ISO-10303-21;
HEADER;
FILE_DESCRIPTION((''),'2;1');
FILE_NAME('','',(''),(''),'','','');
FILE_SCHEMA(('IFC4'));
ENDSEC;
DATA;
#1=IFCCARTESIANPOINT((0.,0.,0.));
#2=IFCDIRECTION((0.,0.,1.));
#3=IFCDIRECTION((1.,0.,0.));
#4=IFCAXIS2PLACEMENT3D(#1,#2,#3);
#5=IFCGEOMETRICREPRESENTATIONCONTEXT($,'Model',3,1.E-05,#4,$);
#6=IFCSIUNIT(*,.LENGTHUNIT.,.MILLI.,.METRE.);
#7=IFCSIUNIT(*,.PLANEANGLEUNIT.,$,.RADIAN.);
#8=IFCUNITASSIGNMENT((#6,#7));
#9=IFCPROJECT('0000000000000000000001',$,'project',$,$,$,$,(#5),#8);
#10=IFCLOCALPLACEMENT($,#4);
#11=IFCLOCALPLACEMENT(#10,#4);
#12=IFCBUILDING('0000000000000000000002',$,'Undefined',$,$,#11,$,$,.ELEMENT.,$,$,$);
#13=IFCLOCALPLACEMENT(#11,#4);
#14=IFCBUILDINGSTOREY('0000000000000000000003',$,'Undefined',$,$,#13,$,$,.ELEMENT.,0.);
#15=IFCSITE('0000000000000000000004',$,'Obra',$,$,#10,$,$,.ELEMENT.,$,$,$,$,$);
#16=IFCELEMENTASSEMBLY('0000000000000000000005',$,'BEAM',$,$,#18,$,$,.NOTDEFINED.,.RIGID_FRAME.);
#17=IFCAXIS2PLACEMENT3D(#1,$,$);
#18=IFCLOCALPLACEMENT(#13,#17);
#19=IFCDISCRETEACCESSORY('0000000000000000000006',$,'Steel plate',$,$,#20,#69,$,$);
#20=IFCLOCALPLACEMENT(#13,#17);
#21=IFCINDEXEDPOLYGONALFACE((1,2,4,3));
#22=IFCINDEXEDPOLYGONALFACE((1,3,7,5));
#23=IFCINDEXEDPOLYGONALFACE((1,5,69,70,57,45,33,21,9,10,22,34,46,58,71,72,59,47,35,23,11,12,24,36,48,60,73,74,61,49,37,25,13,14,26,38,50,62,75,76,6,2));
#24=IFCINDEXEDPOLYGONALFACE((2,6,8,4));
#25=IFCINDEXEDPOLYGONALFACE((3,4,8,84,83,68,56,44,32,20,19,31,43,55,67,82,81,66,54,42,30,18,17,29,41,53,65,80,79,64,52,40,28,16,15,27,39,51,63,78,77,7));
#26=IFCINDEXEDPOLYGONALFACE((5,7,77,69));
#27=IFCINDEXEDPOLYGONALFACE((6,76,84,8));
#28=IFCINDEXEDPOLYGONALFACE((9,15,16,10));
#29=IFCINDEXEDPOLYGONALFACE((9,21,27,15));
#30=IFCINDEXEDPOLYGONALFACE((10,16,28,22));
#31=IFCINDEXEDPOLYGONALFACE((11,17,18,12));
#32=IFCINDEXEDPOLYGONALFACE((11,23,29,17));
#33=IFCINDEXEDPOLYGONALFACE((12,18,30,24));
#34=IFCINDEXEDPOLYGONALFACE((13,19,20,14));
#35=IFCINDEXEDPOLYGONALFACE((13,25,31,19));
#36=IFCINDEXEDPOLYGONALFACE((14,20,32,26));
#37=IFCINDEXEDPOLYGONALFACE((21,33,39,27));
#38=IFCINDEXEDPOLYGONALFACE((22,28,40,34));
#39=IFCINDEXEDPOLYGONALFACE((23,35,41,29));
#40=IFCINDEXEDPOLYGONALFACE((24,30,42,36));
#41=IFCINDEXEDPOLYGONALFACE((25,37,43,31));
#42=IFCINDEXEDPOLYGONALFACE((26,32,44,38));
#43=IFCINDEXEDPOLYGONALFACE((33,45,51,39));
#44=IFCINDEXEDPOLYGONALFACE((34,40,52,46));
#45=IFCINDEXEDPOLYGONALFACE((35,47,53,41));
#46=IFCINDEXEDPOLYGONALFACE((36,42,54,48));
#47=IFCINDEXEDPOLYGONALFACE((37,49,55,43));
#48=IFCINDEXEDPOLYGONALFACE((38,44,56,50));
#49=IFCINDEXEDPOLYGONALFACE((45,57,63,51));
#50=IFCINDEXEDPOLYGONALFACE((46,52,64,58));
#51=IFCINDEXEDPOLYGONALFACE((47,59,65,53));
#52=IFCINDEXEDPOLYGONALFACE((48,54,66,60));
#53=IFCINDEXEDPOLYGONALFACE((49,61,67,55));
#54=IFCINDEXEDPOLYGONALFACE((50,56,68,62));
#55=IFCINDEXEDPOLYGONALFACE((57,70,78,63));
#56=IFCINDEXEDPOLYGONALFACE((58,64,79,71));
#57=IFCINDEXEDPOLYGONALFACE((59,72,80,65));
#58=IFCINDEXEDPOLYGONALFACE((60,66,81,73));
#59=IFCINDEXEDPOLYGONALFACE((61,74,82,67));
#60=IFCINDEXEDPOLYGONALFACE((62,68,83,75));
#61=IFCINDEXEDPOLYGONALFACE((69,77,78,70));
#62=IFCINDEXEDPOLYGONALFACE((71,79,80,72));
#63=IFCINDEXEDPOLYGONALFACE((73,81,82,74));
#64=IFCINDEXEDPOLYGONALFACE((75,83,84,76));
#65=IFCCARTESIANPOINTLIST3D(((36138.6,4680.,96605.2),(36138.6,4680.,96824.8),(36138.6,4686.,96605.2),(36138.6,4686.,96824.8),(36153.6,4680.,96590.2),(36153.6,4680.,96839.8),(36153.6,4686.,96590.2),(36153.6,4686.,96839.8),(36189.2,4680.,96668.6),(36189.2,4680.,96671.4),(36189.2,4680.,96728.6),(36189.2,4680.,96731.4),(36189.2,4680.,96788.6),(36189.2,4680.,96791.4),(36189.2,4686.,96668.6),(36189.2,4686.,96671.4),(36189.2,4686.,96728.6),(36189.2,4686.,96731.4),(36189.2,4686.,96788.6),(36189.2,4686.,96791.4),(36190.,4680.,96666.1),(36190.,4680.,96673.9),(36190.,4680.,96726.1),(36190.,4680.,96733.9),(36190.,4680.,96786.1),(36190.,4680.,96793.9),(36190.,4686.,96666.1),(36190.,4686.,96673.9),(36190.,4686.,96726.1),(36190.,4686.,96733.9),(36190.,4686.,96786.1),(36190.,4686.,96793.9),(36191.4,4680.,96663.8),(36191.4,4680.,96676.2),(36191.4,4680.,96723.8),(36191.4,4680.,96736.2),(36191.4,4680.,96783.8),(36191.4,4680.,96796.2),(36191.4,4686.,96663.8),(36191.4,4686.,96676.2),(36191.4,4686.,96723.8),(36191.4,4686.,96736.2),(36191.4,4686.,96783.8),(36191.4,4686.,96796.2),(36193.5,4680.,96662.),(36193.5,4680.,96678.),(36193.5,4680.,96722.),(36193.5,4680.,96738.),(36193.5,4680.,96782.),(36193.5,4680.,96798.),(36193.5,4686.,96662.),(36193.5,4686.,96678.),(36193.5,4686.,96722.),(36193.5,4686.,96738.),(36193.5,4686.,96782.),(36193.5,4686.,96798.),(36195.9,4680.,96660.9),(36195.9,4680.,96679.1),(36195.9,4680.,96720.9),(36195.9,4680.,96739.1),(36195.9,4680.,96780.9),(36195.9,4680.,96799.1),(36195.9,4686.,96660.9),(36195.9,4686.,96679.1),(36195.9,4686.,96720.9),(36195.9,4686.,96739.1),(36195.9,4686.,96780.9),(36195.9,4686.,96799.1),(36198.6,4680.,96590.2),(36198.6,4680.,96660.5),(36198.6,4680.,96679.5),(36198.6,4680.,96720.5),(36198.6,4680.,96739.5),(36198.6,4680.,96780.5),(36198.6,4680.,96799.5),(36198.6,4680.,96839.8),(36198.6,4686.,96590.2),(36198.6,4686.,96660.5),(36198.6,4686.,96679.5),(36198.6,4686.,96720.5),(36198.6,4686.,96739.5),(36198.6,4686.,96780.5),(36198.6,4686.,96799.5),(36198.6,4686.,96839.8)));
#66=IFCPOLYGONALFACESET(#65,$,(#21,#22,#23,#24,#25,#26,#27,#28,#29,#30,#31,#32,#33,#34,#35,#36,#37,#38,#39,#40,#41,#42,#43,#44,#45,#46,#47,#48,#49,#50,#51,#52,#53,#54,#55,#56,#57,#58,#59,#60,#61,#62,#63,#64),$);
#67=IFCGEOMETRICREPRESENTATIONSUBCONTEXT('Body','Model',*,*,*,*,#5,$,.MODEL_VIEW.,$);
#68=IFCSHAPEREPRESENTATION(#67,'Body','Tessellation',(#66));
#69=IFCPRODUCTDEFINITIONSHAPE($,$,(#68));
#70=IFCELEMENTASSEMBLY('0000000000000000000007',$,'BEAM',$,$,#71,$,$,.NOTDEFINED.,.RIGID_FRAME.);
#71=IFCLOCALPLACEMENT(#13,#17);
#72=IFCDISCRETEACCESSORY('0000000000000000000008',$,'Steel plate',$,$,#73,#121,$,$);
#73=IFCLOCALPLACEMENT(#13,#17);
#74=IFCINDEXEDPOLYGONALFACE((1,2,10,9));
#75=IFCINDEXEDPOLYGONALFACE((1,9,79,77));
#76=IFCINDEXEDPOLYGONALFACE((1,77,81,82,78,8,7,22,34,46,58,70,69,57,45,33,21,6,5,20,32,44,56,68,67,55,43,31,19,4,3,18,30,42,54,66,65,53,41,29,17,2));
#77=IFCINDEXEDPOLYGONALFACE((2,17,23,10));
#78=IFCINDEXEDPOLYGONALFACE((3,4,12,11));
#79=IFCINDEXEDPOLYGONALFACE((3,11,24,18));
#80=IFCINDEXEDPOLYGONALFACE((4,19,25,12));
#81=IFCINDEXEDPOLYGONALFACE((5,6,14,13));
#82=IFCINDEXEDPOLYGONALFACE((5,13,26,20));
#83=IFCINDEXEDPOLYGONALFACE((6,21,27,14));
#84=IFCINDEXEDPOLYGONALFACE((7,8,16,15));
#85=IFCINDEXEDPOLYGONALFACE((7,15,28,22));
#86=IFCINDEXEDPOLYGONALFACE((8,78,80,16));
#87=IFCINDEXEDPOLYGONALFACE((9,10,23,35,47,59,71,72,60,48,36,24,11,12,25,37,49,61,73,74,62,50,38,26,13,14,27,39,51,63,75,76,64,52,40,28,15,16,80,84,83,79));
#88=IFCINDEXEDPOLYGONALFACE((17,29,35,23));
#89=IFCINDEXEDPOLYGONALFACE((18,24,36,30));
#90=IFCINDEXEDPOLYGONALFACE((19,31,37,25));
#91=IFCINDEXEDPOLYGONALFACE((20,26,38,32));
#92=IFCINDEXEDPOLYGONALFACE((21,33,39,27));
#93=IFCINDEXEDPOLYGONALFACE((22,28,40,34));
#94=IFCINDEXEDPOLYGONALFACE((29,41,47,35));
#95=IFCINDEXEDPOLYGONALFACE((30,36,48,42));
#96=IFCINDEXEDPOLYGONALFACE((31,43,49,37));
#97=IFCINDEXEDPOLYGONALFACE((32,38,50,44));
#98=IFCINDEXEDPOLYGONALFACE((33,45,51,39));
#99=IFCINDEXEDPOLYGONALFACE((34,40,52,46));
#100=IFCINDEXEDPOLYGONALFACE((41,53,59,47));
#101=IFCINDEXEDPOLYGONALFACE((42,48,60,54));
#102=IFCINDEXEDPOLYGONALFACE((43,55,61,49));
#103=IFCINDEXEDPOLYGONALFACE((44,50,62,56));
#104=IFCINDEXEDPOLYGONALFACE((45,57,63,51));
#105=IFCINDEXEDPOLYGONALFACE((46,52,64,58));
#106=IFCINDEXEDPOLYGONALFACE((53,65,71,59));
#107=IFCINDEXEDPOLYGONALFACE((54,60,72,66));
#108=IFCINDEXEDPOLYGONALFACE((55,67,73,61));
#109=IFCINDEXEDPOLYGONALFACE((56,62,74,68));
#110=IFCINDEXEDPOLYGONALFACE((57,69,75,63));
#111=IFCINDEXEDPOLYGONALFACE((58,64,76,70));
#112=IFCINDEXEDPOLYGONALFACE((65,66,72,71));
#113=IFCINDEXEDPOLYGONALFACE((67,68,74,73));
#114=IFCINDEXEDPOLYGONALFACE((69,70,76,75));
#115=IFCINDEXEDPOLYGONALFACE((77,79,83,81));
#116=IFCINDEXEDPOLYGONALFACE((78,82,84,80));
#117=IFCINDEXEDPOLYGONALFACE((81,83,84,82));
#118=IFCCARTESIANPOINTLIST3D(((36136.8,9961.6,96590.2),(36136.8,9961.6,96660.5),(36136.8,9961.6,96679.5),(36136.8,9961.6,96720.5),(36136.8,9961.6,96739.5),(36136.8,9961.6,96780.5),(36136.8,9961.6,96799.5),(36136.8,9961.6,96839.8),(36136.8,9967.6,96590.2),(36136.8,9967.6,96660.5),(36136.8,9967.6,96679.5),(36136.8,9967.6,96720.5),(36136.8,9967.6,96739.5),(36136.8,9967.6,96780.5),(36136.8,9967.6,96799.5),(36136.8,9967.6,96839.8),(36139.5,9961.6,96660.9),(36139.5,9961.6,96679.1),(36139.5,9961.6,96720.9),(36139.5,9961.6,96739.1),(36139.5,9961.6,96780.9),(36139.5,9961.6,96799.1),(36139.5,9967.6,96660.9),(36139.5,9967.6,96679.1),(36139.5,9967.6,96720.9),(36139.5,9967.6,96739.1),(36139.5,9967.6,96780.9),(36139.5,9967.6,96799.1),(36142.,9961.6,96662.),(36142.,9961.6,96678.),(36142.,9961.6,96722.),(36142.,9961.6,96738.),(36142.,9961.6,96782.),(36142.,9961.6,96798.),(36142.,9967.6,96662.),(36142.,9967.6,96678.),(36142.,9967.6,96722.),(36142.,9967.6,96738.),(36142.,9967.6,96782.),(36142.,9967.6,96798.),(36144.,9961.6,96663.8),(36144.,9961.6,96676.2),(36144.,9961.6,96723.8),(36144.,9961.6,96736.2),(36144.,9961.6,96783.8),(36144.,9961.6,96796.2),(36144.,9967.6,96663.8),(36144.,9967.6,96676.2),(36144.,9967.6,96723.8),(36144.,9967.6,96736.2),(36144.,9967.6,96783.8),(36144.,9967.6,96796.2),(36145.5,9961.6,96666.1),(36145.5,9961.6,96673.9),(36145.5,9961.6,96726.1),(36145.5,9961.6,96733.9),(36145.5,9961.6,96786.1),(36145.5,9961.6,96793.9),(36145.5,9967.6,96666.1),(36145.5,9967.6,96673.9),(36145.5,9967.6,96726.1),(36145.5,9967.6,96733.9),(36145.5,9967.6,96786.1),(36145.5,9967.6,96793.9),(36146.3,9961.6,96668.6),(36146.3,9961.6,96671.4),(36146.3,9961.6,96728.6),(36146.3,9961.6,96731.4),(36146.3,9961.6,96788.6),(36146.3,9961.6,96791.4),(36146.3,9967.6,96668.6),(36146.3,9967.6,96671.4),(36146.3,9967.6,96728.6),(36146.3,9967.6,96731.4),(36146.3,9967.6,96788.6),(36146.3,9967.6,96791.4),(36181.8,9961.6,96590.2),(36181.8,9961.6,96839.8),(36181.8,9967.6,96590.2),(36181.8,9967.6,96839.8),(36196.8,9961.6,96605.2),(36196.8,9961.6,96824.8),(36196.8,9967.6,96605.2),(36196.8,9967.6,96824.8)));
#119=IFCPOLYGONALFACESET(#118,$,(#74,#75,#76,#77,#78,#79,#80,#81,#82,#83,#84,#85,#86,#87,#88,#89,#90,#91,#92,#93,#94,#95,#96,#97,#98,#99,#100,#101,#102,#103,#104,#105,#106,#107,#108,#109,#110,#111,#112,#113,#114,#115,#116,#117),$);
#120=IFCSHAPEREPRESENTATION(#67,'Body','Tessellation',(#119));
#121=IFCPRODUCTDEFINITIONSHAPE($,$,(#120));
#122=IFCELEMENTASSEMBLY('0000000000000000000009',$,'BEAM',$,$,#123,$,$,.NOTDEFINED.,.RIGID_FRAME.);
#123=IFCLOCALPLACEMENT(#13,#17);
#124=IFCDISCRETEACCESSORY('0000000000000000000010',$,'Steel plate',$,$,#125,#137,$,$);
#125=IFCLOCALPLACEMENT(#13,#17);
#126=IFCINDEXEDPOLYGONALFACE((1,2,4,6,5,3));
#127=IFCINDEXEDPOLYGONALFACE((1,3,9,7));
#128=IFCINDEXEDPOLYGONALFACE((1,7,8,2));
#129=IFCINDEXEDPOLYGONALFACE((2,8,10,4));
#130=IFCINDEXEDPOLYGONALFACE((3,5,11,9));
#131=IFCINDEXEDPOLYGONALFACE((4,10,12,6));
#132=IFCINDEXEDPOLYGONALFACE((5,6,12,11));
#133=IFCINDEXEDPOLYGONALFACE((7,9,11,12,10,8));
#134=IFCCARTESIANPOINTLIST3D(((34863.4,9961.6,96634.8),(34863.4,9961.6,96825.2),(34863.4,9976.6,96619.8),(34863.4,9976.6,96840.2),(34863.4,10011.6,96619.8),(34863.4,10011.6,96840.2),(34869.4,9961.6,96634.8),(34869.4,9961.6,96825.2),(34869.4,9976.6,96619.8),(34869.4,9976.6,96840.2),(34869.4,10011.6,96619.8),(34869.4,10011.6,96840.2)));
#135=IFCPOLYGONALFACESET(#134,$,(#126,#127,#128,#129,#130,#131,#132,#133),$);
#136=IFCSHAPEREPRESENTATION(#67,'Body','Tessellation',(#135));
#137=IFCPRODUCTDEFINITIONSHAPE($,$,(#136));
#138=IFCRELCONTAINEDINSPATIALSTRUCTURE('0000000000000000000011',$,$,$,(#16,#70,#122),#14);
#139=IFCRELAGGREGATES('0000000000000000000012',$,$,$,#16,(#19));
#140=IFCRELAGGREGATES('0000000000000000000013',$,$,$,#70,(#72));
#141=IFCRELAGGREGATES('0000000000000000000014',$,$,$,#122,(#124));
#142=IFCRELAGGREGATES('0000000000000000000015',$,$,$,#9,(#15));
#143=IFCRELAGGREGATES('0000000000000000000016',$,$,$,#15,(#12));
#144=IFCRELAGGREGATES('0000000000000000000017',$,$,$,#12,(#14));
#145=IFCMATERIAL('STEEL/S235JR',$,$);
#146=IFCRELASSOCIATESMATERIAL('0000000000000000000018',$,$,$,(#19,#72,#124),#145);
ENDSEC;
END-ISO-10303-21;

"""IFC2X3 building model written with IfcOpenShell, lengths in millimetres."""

from ifc_helpers import new_model, si_unit, frame, origin_with_axes, origin_2d_with_axis, place, context, subcontext, project, spatial, polyline, circle, outline, extrude, source, transform, mapped, material, element, aggregate, save


model = new_model("IFC2X3")

# Units and contexts
model_context = context("Model", 3, precision=1e-05, world=origin_with_axes())
body_context = subcontext(model_context, "Body", "Model", "MODEL_VIEW")
ifc_project = project(units=[si_unit("LENGTHUNIT", "METRE", prefix="MILLI"), si_unit("PLANEANGLEUNIT", "RADIAN")], contexts=[model_context])

# Site, building, storey
site_placement = place(None, origin_with_axes())
site = spatial("IfcSite", under=ifc_project, at=site_placement, Name="Obra", CompositionType="ELEMENT")
building_placement = place(site_placement, origin_with_axes())
building = spatial("IfcBuilding", under=site, at=building_placement, Name="Undefined", CompositionType="ELEMENT")
storey_placement = place(building_placement, origin_with_axes())
storey = spatial("IfcBuildingStorey", under=building, at=storey_placement, Name="Undefined", CompositionType="ELEMENT", Elevation=0.0)

# Shared definitions
ifc_material = material(Name="STEEL/S235JR")

# Element assembly, discrete accessory, opening
shared_shape = source(origin_with_axes(), body_context, "Body", "SweptSolid", [
    extrude(circle(Radius=9.5, at=origin_2d_with_axis()), frame((0.0, -9.2, 0.0), z_axis=(0.0, 1.0, 0.0), x_axis=(1.0, 0.0, 0.0)), (0.0, 0.0, 1.0), 6.2),
])
assembly_1_placement = place(storey_placement, origin_with_axes())
assembly_1 = element("IfcElementAssembly", 1, at=assembly_1_placement, inside=storey, Name="BEAM", AssemblyPlace="NOTDEFINED", PredefinedType="RIGID_FRAME")
discrete_accessory_1_placement = place(assembly_1_placement, frame((36198.6, 4683.0, 96590.2), z_axis=(0.0, 1.0, 0.0), x_axis=(-1.0, 0.0, 0.0)))
discrete_accessory_1 = element("IfcDiscreteAccessory", 2, at=discrete_accessory_1_placement, material=ifc_material, Name="Steel plate", context=body_context, shape_type="SweptSolid", body=[
    extrude(outline(polyline([(0.0, 0.0), (45.0, 0.0), (60.0, 15.0), (60.0, 234.6), (45.0, 249.6), (0.0, 249.6), (0.0, 0.0)])), frame((0.0, 0.0, -3.0), z_axis=(0.0, 0.0, 1.0), x_axis=(1.0, 0.0, 0.0)), (0.0, 0.0, 1.0), 6.0),
])
opening_1_placement = place(assembly_1_placement, frame((36148.6, 4689.1, 96850.0), z_axis=(1.0, 0.0, 0.0), x_axis=(0.0, 0.0, -1.0)))
element("IfcOpeningElement", 3, at=opening_1_placement, cuts=discrete_accessory_1, ObjectType="Opening", context=body_context, shape_type="MappedRepresentation", body=[
    mapped(shared_shape, transform((60.0, 0.0, 50.0))),
    mapped(shared_shape, transform((120.0, 0.0, 50.0))),
    mapped(shared_shape, transform((180.0, 0.0, 50.0))),
])
aggregate(assembly_1, [discrete_accessory_1])

# Element assembly, discrete accessory, opening
assembly_2_placement = place(storey_placement, origin_with_axes())
assembly_2 = element("IfcElementAssembly", 4, at=assembly_2_placement, inside=storey, Name="BEAM", AssemblyPlace="NOTDEFINED", PredefinedType="RIGID_FRAME")
discrete_accessory_2_placement = place(assembly_2_placement, frame((36136.8, 9964.6, 96590.2), z_axis=(0.0, -1.0, 0.0), x_axis=(1.0, 0.0, 0.0)))
discrete_accessory_2 = element("IfcDiscreteAccessory", 5, at=discrete_accessory_2_placement, material=ifc_material, Name="Steel plate", context=body_context, shape_type="SweptSolid", body=[
    extrude(outline(polyline([(0.0, 0.0), (45.0, 0.0), (60.0, 15.0), (60.0, 234.6), (45.0, 249.6), (0.0, 249.6), (0.0, 0.0)])), frame((0.0, 0.0, -3.0), z_axis=(0.0, 0.0, 1.0), x_axis=(1.0, 0.0, 0.0)), (0.0, 0.0, 1.0), 6.0),
])
opening_2_placement = place(assembly_2_placement, frame((36186.8, 9958.5, 96850.0), z_axis=(-1.0, 0.0, 0.0), x_axis=(0.0, 0.0, -1.0)))
element("IfcOpeningElement", 6, at=opening_2_placement, cuts=discrete_accessory_2, ObjectType="Opening", context=body_context, shape_type="MappedRepresentation", body=[
    mapped(shared_shape, transform((60.0, 0.0, 50.0))),
    mapped(shared_shape, transform((120.0, 0.0, 50.0))),
    mapped(shared_shape, transform((180.0, 0.0, 50.0))),
])
aggregate(assembly_2, [discrete_accessory_2])

# Element assembly, discrete accessory
assembly_3_placement = place(storey_placement, origin_with_axes())
assembly_3 = element("IfcElementAssembly", 7, at=assembly_3_placement, inside=storey, Name="BEAM", AssemblyPlace="NOTDEFINED", PredefinedType="RIGID_FRAME")
discrete_accessory_3_placement = place(assembly_3_placement, frame((34866.4, 10011.6, 96619.8), z_axis=(-1.0, 0.0, 0.0), x_axis=(0.0, -1.0, 0.0)))
discrete_accessory_3 = element("IfcDiscreteAccessory", 8, at=discrete_accessory_3_placement, material=ifc_material, Name="Steel plate", context=body_context, shape_type="SweptSolid", body=[
    extrude(outline(polyline([(0.0, 0.0), (35.0, 0.0), (50.0, 15.0), (50.0, 205.4), (35.0, 220.4), (0.0, 220.4), (0.0, 0.0)])), frame((0.0, 0.0, -3.0), z_axis=(0.0, 0.0, 1.0), x_axis=(1.0, 0.0, 0.0)), (0.0, 0.0, 1.0), 6.0),
])
aggregate(assembly_3, [discrete_accessory_3])

save(model, "model.ifc")
